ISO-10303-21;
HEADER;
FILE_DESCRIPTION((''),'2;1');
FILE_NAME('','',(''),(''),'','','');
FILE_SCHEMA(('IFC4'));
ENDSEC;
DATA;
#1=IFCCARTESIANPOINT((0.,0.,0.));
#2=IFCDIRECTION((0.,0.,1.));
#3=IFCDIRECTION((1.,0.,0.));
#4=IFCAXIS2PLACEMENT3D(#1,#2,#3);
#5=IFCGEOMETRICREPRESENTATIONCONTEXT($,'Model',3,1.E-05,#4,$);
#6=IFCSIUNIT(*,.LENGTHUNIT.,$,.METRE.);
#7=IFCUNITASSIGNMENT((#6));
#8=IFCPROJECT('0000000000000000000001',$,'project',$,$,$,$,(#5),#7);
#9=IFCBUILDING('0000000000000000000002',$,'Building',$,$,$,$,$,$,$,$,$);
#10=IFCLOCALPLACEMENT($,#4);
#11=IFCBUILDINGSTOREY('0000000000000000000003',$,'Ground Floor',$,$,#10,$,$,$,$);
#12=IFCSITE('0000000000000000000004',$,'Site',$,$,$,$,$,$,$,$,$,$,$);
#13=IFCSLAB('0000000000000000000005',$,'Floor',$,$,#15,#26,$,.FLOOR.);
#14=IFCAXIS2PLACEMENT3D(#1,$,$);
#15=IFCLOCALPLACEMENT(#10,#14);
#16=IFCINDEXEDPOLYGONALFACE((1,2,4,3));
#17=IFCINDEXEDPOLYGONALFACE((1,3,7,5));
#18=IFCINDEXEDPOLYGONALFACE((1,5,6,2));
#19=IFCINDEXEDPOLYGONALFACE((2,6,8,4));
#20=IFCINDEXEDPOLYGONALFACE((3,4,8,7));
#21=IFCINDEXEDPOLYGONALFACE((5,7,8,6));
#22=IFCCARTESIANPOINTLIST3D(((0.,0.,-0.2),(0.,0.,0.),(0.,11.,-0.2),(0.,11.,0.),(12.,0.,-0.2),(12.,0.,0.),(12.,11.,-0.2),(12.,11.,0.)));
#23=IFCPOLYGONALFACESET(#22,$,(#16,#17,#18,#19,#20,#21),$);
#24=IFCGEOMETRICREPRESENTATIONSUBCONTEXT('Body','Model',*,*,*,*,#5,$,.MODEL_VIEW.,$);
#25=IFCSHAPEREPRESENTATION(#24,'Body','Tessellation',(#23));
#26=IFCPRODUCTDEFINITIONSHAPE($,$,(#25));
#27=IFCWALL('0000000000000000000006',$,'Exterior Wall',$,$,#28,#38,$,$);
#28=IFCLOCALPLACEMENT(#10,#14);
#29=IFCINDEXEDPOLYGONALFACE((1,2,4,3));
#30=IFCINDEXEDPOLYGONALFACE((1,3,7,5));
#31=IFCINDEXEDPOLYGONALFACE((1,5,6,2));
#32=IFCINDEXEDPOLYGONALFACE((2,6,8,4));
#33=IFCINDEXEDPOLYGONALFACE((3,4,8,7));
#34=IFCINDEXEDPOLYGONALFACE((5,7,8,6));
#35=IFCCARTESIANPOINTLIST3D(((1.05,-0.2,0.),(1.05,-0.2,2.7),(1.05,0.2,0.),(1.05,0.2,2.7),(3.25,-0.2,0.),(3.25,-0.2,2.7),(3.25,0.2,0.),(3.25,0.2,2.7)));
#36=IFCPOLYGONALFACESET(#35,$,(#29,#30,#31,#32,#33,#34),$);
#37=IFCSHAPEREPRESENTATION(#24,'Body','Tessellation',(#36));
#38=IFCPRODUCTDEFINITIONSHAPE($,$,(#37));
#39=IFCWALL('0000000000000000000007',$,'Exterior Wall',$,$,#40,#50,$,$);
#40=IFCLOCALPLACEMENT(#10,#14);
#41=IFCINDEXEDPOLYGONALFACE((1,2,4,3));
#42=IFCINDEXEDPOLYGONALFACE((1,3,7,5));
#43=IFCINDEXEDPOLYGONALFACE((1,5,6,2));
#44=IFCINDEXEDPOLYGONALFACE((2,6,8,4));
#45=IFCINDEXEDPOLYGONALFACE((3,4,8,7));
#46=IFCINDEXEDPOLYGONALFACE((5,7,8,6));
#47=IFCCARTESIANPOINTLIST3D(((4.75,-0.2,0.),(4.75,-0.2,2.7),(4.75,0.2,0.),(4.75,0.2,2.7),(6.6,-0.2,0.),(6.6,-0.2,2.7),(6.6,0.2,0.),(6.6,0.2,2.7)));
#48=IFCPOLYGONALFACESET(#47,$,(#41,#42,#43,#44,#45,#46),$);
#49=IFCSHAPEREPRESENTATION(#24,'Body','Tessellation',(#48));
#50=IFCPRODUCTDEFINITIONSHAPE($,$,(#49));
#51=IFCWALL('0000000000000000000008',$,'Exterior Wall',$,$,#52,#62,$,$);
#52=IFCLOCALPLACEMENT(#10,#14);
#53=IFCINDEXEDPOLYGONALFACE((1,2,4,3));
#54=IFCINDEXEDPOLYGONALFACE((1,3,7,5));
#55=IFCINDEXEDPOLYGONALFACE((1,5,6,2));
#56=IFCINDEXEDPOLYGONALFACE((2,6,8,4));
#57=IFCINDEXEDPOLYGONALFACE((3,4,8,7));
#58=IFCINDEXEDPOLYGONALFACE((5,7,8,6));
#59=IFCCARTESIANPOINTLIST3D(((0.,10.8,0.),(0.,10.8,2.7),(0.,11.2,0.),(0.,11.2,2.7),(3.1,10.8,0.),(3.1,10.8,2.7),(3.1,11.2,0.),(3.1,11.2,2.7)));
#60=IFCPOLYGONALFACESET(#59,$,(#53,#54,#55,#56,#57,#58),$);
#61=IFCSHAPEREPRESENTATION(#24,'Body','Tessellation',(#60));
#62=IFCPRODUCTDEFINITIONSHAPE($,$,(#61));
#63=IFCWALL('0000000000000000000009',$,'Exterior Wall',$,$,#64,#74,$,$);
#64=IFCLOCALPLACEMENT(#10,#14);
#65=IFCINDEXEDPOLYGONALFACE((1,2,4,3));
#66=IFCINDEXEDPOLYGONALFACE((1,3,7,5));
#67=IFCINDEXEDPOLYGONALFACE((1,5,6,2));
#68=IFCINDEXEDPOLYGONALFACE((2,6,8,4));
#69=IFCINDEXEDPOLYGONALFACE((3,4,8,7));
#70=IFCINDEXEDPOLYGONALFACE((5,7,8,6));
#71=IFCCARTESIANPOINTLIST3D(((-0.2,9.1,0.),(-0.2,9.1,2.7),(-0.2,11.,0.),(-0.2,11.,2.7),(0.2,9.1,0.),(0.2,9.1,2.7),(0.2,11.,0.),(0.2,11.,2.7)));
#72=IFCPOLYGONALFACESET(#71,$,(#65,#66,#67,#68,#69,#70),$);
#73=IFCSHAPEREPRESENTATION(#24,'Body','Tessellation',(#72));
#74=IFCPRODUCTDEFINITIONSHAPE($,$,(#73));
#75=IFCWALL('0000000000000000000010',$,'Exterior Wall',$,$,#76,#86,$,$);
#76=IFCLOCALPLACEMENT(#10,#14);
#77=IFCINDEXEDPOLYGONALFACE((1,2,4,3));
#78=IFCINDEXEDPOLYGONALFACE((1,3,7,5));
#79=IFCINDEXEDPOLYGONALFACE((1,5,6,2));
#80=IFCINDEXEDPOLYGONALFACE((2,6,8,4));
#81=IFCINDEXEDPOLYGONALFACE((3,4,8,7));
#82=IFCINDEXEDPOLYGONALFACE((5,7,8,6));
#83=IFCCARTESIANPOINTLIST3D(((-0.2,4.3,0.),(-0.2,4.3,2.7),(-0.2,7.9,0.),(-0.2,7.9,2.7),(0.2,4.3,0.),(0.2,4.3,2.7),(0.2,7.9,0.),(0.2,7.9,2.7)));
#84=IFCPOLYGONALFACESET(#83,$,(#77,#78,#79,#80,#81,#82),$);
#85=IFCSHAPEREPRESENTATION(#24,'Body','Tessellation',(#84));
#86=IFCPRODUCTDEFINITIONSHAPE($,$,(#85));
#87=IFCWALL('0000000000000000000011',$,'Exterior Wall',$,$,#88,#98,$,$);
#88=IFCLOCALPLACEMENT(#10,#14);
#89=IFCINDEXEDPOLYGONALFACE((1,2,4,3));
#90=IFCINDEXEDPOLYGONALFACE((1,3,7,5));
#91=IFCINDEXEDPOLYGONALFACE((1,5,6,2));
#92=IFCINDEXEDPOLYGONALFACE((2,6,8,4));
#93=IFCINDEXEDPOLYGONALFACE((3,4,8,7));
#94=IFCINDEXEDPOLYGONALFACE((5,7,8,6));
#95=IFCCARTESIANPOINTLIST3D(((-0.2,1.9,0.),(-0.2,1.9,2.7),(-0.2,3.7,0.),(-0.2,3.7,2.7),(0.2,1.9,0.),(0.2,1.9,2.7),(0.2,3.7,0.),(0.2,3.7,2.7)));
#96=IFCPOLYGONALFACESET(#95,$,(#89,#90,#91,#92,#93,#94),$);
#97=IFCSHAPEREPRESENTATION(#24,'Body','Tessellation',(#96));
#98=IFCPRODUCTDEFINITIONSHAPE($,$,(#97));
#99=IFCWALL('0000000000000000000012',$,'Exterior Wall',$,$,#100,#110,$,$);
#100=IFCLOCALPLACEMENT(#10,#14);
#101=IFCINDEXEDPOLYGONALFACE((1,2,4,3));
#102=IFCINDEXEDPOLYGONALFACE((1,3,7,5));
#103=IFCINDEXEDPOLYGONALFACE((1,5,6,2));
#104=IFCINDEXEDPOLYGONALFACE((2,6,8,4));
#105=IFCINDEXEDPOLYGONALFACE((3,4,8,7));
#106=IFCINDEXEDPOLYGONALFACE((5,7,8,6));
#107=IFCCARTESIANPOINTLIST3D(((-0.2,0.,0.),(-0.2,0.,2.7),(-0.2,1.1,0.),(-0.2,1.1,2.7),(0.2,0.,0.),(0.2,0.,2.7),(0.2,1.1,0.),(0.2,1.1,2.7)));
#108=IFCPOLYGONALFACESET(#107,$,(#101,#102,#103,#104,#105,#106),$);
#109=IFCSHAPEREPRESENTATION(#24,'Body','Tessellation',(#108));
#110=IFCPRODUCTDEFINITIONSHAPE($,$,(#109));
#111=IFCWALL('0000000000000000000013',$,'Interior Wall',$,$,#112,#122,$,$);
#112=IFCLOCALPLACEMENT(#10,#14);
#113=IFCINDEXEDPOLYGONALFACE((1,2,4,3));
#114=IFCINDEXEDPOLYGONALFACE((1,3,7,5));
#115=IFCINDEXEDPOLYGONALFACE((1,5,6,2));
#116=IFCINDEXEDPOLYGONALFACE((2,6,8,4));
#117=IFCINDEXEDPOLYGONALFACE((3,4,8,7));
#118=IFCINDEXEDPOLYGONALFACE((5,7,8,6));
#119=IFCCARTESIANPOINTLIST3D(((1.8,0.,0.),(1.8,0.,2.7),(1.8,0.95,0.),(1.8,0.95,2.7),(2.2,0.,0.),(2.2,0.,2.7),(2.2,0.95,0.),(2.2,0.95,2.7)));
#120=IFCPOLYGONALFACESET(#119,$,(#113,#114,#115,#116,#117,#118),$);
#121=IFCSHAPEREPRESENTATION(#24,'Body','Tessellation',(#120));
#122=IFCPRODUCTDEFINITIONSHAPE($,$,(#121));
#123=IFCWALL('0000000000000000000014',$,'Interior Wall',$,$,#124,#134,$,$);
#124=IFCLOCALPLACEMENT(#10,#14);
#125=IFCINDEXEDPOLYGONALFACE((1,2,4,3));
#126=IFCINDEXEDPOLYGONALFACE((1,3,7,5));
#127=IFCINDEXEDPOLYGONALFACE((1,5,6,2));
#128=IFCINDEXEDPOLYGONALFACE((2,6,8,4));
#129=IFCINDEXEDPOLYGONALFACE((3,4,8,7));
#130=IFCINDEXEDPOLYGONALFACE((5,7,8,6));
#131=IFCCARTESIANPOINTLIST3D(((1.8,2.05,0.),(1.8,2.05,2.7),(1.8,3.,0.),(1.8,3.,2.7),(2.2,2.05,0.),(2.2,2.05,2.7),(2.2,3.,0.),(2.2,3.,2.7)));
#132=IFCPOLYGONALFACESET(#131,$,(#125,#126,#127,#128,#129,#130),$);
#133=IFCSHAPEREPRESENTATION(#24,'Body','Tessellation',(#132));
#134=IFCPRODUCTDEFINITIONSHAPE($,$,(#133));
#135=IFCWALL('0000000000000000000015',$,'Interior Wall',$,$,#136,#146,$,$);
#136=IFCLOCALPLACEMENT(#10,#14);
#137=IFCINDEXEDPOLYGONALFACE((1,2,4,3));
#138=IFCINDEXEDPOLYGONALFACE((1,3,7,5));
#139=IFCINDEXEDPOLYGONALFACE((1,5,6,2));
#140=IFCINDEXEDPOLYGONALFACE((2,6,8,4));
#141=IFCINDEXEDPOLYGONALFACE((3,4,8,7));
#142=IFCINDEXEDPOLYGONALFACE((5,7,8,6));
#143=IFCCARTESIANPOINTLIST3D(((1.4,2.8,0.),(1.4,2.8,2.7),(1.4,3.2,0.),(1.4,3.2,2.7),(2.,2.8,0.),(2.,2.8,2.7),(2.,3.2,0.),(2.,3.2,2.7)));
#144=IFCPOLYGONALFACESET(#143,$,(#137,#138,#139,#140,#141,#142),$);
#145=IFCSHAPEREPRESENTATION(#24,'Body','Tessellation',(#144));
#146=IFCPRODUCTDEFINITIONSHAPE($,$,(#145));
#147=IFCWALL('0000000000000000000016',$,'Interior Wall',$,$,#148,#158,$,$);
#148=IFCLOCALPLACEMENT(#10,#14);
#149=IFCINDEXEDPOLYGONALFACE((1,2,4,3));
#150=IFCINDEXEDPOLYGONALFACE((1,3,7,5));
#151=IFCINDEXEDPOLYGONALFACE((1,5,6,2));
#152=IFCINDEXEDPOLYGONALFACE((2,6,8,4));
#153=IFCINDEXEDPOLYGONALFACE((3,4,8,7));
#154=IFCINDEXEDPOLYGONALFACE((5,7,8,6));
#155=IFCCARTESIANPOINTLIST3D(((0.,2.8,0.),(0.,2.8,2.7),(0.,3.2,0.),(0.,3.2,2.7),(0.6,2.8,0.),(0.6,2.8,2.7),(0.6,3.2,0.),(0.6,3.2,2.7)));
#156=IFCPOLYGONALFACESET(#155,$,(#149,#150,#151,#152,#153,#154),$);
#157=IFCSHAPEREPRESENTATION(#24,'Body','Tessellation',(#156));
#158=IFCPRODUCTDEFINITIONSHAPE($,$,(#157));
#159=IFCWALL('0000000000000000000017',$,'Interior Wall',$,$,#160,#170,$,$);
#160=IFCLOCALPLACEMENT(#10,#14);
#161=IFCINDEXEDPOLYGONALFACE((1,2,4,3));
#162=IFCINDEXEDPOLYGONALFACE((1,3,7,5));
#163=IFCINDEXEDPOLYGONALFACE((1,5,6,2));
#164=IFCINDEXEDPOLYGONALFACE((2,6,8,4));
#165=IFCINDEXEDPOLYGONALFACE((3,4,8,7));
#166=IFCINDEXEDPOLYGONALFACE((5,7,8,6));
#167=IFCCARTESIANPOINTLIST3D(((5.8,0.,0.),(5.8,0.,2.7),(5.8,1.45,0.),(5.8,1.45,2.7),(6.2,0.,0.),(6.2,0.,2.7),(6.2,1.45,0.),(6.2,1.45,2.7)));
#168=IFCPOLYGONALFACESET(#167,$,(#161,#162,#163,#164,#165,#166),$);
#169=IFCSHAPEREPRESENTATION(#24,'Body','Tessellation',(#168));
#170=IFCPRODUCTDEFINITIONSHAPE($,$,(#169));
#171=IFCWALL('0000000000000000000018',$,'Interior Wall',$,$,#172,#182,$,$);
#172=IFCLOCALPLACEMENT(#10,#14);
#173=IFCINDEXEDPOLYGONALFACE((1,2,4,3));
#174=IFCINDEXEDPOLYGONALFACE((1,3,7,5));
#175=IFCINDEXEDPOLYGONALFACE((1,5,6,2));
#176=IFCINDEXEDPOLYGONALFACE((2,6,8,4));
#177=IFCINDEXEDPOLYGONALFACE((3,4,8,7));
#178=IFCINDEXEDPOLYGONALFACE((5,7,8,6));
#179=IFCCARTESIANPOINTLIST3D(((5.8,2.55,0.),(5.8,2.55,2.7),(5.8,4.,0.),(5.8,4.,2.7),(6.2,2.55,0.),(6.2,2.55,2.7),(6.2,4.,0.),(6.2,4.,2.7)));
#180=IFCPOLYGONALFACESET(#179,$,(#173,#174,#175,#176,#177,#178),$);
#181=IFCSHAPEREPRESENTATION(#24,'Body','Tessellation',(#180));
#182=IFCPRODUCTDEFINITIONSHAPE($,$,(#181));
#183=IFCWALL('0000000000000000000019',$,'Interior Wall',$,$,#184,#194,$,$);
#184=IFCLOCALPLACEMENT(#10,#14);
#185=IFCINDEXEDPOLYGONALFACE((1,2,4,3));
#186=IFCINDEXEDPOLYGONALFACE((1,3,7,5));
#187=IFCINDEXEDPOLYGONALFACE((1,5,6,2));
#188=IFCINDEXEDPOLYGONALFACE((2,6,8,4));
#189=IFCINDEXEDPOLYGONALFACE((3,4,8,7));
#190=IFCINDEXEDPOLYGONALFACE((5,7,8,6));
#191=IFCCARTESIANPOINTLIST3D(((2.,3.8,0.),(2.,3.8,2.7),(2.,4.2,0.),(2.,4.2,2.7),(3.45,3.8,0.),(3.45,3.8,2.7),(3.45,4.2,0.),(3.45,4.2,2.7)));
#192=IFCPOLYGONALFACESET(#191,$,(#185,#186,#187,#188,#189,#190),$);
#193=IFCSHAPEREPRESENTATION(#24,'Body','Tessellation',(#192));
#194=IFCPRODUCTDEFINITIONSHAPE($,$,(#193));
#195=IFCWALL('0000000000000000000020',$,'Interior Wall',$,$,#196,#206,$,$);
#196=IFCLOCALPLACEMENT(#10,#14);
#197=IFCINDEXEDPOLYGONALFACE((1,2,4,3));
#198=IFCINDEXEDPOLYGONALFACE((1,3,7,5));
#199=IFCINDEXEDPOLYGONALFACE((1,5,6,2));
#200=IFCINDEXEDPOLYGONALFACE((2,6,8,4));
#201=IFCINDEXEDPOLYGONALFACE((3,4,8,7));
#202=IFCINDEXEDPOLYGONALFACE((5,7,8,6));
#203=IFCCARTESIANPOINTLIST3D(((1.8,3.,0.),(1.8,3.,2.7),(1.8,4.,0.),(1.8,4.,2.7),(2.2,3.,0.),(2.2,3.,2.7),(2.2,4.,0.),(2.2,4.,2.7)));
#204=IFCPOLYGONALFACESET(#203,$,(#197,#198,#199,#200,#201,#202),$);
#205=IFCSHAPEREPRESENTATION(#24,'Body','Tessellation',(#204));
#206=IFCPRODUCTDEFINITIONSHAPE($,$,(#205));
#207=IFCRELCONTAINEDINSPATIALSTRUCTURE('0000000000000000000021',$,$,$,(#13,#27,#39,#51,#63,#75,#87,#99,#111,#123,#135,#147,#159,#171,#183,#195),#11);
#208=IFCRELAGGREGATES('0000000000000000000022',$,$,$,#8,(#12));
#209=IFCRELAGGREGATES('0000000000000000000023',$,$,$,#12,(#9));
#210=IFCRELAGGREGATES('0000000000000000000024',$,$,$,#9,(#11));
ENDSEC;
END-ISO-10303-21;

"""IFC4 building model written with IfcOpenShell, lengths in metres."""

from ifc_helpers import new_model, si_unit, frame, origin_with_axes, place, context, subcontext, project, spatial, indexed_curve, outline, extrude, element, save


model = new_model("IFC4")

# Units and contexts
model_context = context("Model", 3, precision=1e-05, world=origin_with_axes())
body_context = subcontext(model_context, "Body", "Model", "MODEL_VIEW")
ifc_project = project(units=[si_unit("LENGTHUNIT", "METRE")], contexts=[model_context])

# Site, building, storey
site = spatial("IfcSite", under=ifc_project, Name="Site")
building = spatial("IfcBuilding", under=site, Name="Building")
storey_placement = place(None, origin_with_axes())
storey = spatial("IfcBuildingStorey", under=building, at=storey_placement, Name="Ground Floor")

# Slab
slab_placement = place(storey_placement, frame((0.0, 0.0, -0.2), z_axis=(0.0, 0.0, 1.0), x_axis=(1.0, 0.0, 0.0)))
element("IfcSlab", 1, at=slab_placement, inside=storey, Name="Floor", PredefinedType="FLOOR", context=body_context, shape_type="SweptSolid", body=[
    extrude(outline(indexed_curve([(0.0, 0.0), (12.0, 0.0), (12.0, 11.0), (0.0, 11.0)])), None, (0.0, 0.0, 1.0), 0.2),
])

# Walls
wall_1_placement = place(storey_placement, frame((1.05, 0.0, 0.0), z_axis=(0.0, 0.0, 1.0), x_axis=(1.0, 0.0, 0.0)))
element("IfcWall", 2, at=wall_1_placement, inside=storey, Name="Exterior Wall", context=body_context, shape_type="SweptSolid", body=[
    extrude(outline(indexed_curve([(0.0, 0.0), (0.0, 0.4), (2.2, 0.4), (2.2, 0.0), (0.0, 0.0)], self_intersect=False)), frame((0.0, -0.2, 0.0), z_axis=(0.0, 0.0, 1.0), x_axis=(1.0, 0.0, 0.0)), (0.0, 0.0, 1.0), 2.7),
])
wall_2_placement = place(storey_placement, frame((4.75, 0.0, 0.0), z_axis=(0.0, 0.0, 1.0), x_axis=(1.0, 0.0, 0.0)))
element("IfcWall", 3, at=wall_2_placement, inside=storey, Name="Exterior Wall", context=body_context, shape_type="SweptSolid", body=[
    extrude(outline(indexed_curve([(0.0, 0.0), (0.0, 0.4), (1.85, 0.4), (1.85, 0.0), (0.0, 0.0)], self_intersect=False)), frame((0.0, -0.2, 0.0), z_axis=(0.0, 0.0, 1.0), x_axis=(1.0, 0.0, 0.0)), (0.0, 0.0, 1.0), 2.7),
])
wall_3_placement = place(storey_placement, frame((3.1, 11.0, 0.0), z_axis=(0.0, 0.0, 1.0), x_axis=(-1.0, 0.0, 0.0)))
element("IfcWall", 4, at=wall_3_placement, inside=storey, Name="Exterior Wall", context=body_context, shape_type="SweptSolid", body=[
    extrude(outline(indexed_curve([(0.0, 0.0), (0.0, 0.4), (3.1, 0.4), (3.1, 0.0), (0.0, 0.0)], self_intersect=False)), frame((0.0, -0.2, 0.0), z_axis=(0.0, 0.0, 1.0), x_axis=(1.0, 0.0, 0.0)), (0.0, 0.0, 1.0), 2.7),
])
wall_4_placement = place(storey_placement, frame((0.0, 11.0, 0.0), z_axis=(0.0, 0.0, 1.0), x_axis=(0.0, -1.0, 0.0)))
element("IfcWall", 5, at=wall_4_placement, inside=storey, Name="Exterior Wall", context=body_context, shape_type="SweptSolid", body=[
    extrude(outline(indexed_curve([(0.0, 0.0), (0.0, 0.4), (1.9, 0.4), (1.9, 0.0), (0.0, 0.0)], self_intersect=False)), frame((0.0, -0.2, 0.0), z_axis=(0.0, 0.0, 1.0), x_axis=(1.0, 0.0, 0.0)), (0.0, 0.0, 1.0), 2.7),
])
wall_5_placement = place(storey_placement, frame((0.0, 7.9, 0.0), z_axis=(0.0, 0.0, 1.0), x_axis=(0.0, -1.0, 0.0)))
element("IfcWall", 6, at=wall_5_placement, inside=storey, Name="Exterior Wall", context=body_context, shape_type="SweptSolid", body=[
    extrude(outline(indexed_curve([(0.0, 0.0), (0.0, 0.4), (3.6, 0.4), (3.6, 0.0), (0.0, 0.0)], self_intersect=False)), frame((0.0, -0.2, 0.0), z_axis=(0.0, 0.0, 1.0), x_axis=(1.0, 0.0, 0.0)), (0.0, 0.0, 1.0), 2.7),
])
wall_6_placement = place(storey_placement, frame((0.0, 3.7, 0.0), z_axis=(0.0, 0.0, 1.0), x_axis=(0.0, -1.0, 0.0)))
element("IfcWall", 7, at=wall_6_placement, inside=storey, Name="Exterior Wall", context=body_context, shape_type="SweptSolid", body=[
    extrude(outline(indexed_curve([(0.0, 0.0), (0.0, 0.4), (1.8, 0.4), (1.8, 0.0), (0.0, 0.0)], self_intersect=False)), frame((0.0, -0.2, 0.0), z_axis=(0.0, 0.0, 1.0), x_axis=(1.0, 0.0, 0.0)), (0.0, 0.0, 1.0), 2.7),
])
wall_7_placement = place(storey_placement, frame((0.0, 1.1, 0.0), z_axis=(0.0, 0.0, 1.0), x_axis=(0.0, -1.0, 0.0)))
element("IfcWall", 8, at=wall_7_placement, inside=storey, Name="Exterior Wall", context=body_context, shape_type="SweptSolid", body=[
    extrude(outline(indexed_curve([(0.0, 0.0), (0.0, 0.4), (1.1, 0.4), (1.1, 0.0), (0.0, 0.0)], self_intersect=False)), frame((0.0, -0.2, 0.0), z_axis=(0.0, 0.0, 1.0), x_axis=(1.0, 0.0, 0.0)), (0.0, 0.0, 1.0), 2.7),
])
wall_8_placement = place(storey_placement, frame((2.0, 0.0, 0.0), z_axis=(0.0, 0.0, 1.0), x_axis=(0.0, 1.0, 0.0)))
element("IfcWall", 9, at=wall_8_placement, inside=storey, Name="Interior Wall", context=body_context, shape_type="SweptSolid", body=[
    extrude(outline(indexed_curve([(0.0, 0.0), (0.0, 0.4), (0.95, 0.4), (0.95, 0.0), (0.0, 0.0)], self_intersect=False)), frame((0.0, -0.2, 0.0), z_axis=(0.0, 0.0, 1.0), x_axis=(1.0, 0.0, 0.0)), (0.0, 0.0, 1.0), 2.7),
])
wall_9_placement = place(storey_placement, frame((2.0, 2.05, 0.0), z_axis=(0.0, 0.0, 1.0), x_axis=(0.0, 1.0, 0.0)))
element("IfcWall", 10, at=wall_9_placement, inside=storey, Name="Interior Wall", context=body_context, shape_type="SweptSolid", body=[
    extrude(outline(indexed_curve([(0.0, 0.0), (0.0, 0.4), (0.95, 0.4), (0.95, 0.0), (0.0, 0.0)], self_intersect=False)), frame((0.0, -0.2, 0.0), z_axis=(0.0, 0.0, 1.0), x_axis=(1.0, 0.0, 0.0)), (0.0, 0.0, 1.0), 2.7),
])
for number, where, z_axis, x_axis, name in (
    (11, (2.0, 3.0, 0.0), (0.0, 0.0, 1.0), (-1.0, 0.0, 0.0), "Interior Wall"),
    (12, (0.6, 3.0, 0.0), (0.0, 0.0, 1.0), (-1.0, 0.0, 0.0), "Interior Wall"),
):
    element("IfcWall", number, at=place(storey_placement, frame(where, z_axis=z_axis, x_axis=x_axis)), inside=storey, Name=name, context=body_context, shape_type="SweptSolid", body=[
        extrude(outline(indexed_curve([(0.0, 0.0), (0.0, 0.4), (0.6, 0.4), (0.6, 0.0), (0.0, 0.0)], self_intersect=False)), frame((0.0, -0.2, 0.0), z_axis=(0.0, 0.0, 1.0), x_axis=(1.0, 0.0, 0.0)), (0.0, 0.0, 1.0), 2.7),
    ])
wall_10_placement = place(storey_placement, frame((6.0, 0.0, 0.0), z_axis=(0.0, 0.0, 1.0), x_axis=(0.0, 1.0, 0.0)))
element("IfcWall", 13, at=wall_10_placement, inside=storey, Name="Interior Wall", context=body_context, shape_type="SweptSolid", body=[
    extrude(outline(indexed_curve([(0.0, 0.0), (0.0, 0.4), (1.45, 0.4), (1.45, 0.0), (0.0, 0.0)], self_intersect=False)), frame((0.0, -0.2, 0.0), z_axis=(0.0, 0.0, 1.0), x_axis=(1.0, 0.0, 0.0)), (0.0, 0.0, 1.0), 2.7),
])
for number, where, z_axis, x_axis, name in (
    (14, (6.0, 2.55, 0.0), (0.0, 0.0, 1.0), (0.0, 1.0, 0.0), "Interior Wall"),
    (15, (3.45, 4.0, 0.0), (0.0, 0.0, 1.0), (-1.0, 0.0, 0.0), "Interior Wall"),
):
    element("IfcWall", number, at=place(storey_placement, frame(where, z_axis=z_axis, x_axis=x_axis)), inside=storey, Name=name, context=body_context, shape_type="SweptSolid", body=[
        extrude(outline(indexed_curve([(0.0, 0.0), (0.0, 0.4), (1.45, 0.4), (1.45, 0.0), (0.0, 0.0)], self_intersect=False)), frame((0.0, -0.2, 0.0), z_axis=(0.0, 0.0, 1.0), x_axis=(1.0, 0.0, 0.0)), (0.0, 0.0, 1.0), 2.7),
    ])
for number, where, z_axis, x_axis, name in (
    (16, (2.0, 4.0, 0.0), (0.0, 0.0, 1.0), (0.0, -1.0, 0.0), "Interior Wall"),
):
    element("IfcWall", number, at=place(storey_placement, frame(where, z_axis=z_axis, x_axis=x_axis)), inside=storey, Name=name, context=body_context, shape_type="SweptSolid", body=[
        extrude(outline(indexed_curve([(0.0, 0.0), (0.0, 0.4), (1.0, 0.4), (1.0, 0.0), (0.0, 0.0)], self_intersect=False)), frame((0.0, -0.2, 0.0), z_axis=(0.0, 0.0, 1.0), x_axis=(1.0, 0.0, 0.0)), (0.0, 0.0, 1.0), 2.7),
    ])

save(model, "model.ifc")
